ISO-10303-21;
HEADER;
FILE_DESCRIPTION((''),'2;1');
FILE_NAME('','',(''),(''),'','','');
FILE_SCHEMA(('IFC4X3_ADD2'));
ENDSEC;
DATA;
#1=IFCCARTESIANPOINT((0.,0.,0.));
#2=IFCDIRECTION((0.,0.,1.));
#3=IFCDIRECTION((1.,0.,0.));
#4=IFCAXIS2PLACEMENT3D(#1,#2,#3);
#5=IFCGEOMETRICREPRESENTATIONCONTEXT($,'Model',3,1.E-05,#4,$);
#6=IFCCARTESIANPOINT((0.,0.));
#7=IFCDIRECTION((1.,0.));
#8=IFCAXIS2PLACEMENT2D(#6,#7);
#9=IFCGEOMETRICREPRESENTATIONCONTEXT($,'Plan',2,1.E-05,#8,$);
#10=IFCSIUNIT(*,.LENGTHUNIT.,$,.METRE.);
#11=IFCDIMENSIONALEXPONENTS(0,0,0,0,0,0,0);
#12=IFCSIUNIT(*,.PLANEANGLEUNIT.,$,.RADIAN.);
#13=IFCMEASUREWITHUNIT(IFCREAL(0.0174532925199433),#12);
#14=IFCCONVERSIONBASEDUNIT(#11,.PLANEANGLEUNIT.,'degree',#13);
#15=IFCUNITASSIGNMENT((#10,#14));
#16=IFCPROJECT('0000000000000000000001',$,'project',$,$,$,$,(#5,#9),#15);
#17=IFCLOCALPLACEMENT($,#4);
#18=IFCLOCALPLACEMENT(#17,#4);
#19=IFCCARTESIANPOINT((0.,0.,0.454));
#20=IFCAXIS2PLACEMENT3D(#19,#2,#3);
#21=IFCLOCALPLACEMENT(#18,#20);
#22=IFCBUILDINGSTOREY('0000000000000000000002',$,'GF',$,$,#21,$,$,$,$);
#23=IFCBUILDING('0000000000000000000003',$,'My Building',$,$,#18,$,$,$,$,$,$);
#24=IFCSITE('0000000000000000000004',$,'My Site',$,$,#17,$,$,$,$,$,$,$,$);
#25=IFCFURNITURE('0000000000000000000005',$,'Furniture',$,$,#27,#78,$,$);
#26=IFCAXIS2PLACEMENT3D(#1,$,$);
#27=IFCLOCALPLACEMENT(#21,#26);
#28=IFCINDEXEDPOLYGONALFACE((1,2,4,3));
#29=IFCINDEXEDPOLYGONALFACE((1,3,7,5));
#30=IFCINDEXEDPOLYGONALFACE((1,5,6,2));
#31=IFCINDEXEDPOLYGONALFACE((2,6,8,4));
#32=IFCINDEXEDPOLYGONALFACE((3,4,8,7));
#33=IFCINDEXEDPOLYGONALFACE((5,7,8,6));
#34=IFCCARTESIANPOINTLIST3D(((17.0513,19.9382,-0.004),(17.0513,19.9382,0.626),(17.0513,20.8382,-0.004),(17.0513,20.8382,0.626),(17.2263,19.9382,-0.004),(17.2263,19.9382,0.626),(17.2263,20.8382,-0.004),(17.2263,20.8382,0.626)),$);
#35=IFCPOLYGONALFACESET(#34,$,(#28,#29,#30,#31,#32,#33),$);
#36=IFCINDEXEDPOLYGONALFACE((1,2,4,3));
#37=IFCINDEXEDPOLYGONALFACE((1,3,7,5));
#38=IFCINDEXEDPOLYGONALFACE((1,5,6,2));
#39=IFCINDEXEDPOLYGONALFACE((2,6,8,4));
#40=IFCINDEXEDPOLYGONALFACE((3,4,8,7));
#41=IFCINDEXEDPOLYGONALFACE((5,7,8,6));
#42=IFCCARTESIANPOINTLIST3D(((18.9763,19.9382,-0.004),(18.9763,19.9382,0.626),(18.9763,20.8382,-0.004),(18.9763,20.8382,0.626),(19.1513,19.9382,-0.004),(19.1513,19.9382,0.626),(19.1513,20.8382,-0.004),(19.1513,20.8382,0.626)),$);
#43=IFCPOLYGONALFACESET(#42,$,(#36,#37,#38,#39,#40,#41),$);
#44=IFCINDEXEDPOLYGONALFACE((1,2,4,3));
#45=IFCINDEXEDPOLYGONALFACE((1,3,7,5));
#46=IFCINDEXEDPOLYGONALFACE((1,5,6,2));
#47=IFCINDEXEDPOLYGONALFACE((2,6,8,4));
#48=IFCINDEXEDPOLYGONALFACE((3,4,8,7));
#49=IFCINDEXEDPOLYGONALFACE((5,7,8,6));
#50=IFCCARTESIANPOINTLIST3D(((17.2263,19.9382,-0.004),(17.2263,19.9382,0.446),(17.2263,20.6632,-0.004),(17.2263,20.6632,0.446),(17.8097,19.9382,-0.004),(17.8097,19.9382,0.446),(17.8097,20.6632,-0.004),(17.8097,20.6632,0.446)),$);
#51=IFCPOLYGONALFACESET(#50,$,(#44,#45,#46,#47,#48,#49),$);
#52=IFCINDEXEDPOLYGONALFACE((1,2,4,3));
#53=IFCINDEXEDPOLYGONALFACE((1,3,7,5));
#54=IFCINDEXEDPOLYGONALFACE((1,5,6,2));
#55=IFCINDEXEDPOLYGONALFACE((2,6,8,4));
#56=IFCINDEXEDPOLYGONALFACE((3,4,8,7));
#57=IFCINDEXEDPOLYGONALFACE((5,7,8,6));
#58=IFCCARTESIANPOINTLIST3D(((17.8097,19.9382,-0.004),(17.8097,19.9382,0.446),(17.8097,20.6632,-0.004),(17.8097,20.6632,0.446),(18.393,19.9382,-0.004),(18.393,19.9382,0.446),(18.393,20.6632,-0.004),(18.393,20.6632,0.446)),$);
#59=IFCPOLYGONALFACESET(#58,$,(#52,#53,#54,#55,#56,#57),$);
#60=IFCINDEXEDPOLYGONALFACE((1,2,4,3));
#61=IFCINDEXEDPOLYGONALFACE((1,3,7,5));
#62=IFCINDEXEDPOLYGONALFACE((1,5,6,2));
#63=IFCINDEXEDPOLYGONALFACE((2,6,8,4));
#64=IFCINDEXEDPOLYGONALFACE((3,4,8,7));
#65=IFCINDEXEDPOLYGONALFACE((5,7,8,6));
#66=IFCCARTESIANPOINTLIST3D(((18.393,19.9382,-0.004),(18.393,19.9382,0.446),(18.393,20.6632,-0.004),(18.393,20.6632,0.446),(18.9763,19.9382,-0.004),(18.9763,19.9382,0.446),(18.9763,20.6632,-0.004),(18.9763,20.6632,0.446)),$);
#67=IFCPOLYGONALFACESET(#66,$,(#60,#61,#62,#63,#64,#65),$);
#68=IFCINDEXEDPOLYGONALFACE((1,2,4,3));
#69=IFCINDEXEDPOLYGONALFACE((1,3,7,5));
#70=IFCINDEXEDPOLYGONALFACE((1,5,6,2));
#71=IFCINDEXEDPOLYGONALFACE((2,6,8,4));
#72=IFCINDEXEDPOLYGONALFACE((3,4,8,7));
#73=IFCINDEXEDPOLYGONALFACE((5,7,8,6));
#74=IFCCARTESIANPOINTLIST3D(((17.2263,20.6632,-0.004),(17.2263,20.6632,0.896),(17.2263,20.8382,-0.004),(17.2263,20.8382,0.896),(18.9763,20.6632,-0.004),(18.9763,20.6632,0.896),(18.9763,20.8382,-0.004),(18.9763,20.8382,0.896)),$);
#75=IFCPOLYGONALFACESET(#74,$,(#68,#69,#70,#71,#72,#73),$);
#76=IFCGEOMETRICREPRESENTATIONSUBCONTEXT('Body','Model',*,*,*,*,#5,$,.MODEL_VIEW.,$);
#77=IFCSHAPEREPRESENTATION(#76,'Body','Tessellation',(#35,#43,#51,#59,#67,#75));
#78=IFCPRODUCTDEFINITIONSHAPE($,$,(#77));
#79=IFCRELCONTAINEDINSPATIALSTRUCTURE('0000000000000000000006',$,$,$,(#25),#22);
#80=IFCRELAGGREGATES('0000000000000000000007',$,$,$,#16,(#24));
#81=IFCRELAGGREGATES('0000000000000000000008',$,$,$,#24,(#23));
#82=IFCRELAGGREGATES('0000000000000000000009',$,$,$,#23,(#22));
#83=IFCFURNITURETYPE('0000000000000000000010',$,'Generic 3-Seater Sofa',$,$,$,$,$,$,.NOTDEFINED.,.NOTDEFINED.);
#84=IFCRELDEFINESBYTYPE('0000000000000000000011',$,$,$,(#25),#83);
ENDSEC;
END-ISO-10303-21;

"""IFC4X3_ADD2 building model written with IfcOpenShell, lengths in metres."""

from ifc_helpers import new_model, entity, si_unit, converted_unit, frame, origin_with_axes, origin_2d_with_axis, place, context, subcontext, project, spatial, line, indexed_curve, outline, extrude, shape, source, transform, mapped, type_object, type_shapes, element, save


model = new_model("IFC4X3_ADD2")

# Units and contexts
model_context = context("Model", 3, precision=1e-05, world=origin_with_axes())
plan_context = context("Plan", 2, precision=1e-05, world=origin_2d_with_axis())
body_context_1 = subcontext(model_context, "Body", "Model", "MODEL_VIEW")
body_context_2 = subcontext(plan_context, "Body", "Plan", "PLAN_VIEW")
ifc_project = project(units=[si_unit("LENGTHUNIT", "METRE"), converted_unit("PLANEANGLEUNIT", "degree", entity("IfcReal", 0.0174532925199433), si_unit("PLANEANGLEUNIT", "RADIAN"), dimensions=[0, 0, 0, 0, 0, 0, 0])], contexts=[model_context, plan_context])

# Site, building, storey
site_placement = place(None, origin_with_axes())
site = spatial("IfcSite", under=ifc_project, at=site_placement, Name="My Site")
building_placement = place(site_placement, origin_with_axes())
building = spatial("IfcBuilding", under=site, at=building_placement, Name="My Building")
storey_placement = place(building_placement, frame((0.0, 0.0, 0.454), z_axis=(0.0, 0.0, 1.0), x_axis=(1.0, 0.0, 0.0)))
storey = spatial("IfcBuildingStorey", under=building, at=storey_placement, Name="GF")

# Furniture
furniture_type_1 = type_object("IfcFurnitureType", Name="Generic 3-Seater Sofa", AssemblyPlace="NOTDEFINED", PredefinedType="NOTDEFINED")
shared_shape_1 = source(origin_with_axes(), body_context_1, "Body", "SweptSolid", [
    extrude(outline(indexed_curve([(0.0, 0.0), (0.175, 0.0), (0.175, 0.9), (0.0, 0.9)], segments=[line(4, 1), line(1, 2), line(2, 3), line(3, 4)], self_intersect=False)), frame((-1.05, -0.9, 0.0), z_axis=(0.0, 0.0, 1.0), x_axis=(1.0, 0.0, 0.0)), (0.0, 0.0, 1.0), 0.63),
    extrude(outline(indexed_curve([(0.0, 0.0), (0.175, 0.0), (0.175, 0.9), (0.0, 0.9)], segments=[line(1, 2, 3, 4, 1)])), frame((0.875, -0.9, 0.0), z_axis=(0.0, 0.0, 1.0), x_axis=(1.0, 0.0, 0.0)), (0.0, 0.0, 1.0), 0.63),
    extrude(outline(indexed_curve([(0.175, 0.0), (0.7583, 0.0), (0.7583, 0.725), (0.175, 0.725)], segments=[line(1, 2, 3, 4, 1)])), frame((-1.05, -0.9, 0.0), z_axis=(0.0, 0.0, 1.0), x_axis=(1.0, 0.0, 0.0)), (0.0, 0.0, 1.0), 0.45),
    extrude(outline(indexed_curve([(0.7583, 0.0), (1.3417, 0.0), (1.3417, 0.725), (0.7583, 0.725)], segments=[line(1, 2, 3, 4, 1)])), frame((-1.05, -0.9, 0.0), z_axis=(0.0, 0.0, 1.0), x_axis=(1.0, 0.0, 0.0)), (0.0, 0.0, 1.0), 0.45),
    extrude(outline(indexed_curve([(1.3417, 0.0), (1.925, 0.0), (1.925, 0.725), (1.3417, 0.725)], segments=[line(1, 2, 3, 4, 1)])), frame((-1.05, -0.9, 0.0), z_axis=(0.0, 0.0, 1.0), x_axis=(1.0, 0.0, 0.0)), (0.0, 0.0, 1.0), 0.45),
    extrude(outline(indexed_curve([(0.175, 0.725), (1.925, 0.725), (1.925, 0.9), (0.175, 0.9)], segments=[line(1, 2, 3, 4, 1)])), frame((-1.05, -0.9, 0.0), z_axis=(0.0, 0.0, 1.0), x_axis=(1.0, 0.0, 0.0)), (0.0, 0.0, 1.0), 0.9),
])
shared_shape_2 = source(origin_with_axes(), body_context_2, "Body", "Annotation2D", [
    entity("IfcGeometricCurveSet", [entity("IfcIndexedPolyCurve", entity("IfcCartesianPointList2D", [[0.2917, -0.175], [0.2917, -0.9], [0.875, -0.9], [0.875, -0.175], [-0.875, -0.175], [-0.875, 0.0], [0.875, 0.0], [1.05, 0.0], [1.05, -0.9], [0.875, -0.9], [0.875, 0.0], [0.875, -0.175], [0.2917, -0.175], [-0.2917, -0.175], [-0.2917, -0.9], [-0.875, -0.9], [-0.875, 0.0], [-1.05, 0.0], [-1.05, -0.9], [-0.875, -0.9], [-0.875, -0.175], [-0.2917, -0.175]])), entity("IfcIndexedPolyCurve", entity("IfcCartesianPointList2D", [[0.2917, -0.9], [-0.2917, -0.9]]))]),
])
type_shapes(furniture_type_1, [shared_shape_1, shared_shape_2])
furniture_1_placement = place(storey_placement, frame((18.1013, 20.8382, -0.004), z_axis=(0.0, 0.0, 1.0), x_axis=(1.0, 0.0, 0.0)))
element("IfcFurniture", 1, at=furniture_1_placement, inside=storey, type_object=furniture_type_1, Name="Furniture", shapes=[
    shape(body_context_1, "Body", "MappedRepresentation", [mapped(shared_shape_1, transform((0.0, 0.0, 0.0), x_axis=(1.0, 0.0, 0.0), y_axis=(0.0, 1.0, 0.0), z_axis=(0.0, 0.0, 1.0), scale=1.0))]),
    shape(body_context_2, "Body", "MappedRepresentation", [mapped(shared_shape_2, transform((0.0, 0.0, 0.0), x_axis=(1.0, 0.0, 0.0), y_axis=(0.0, 1.0, 0.0), z_axis=(0.0, 0.0, 1.0), scale=1.0))]),
])

save(model, "model.ifc")
